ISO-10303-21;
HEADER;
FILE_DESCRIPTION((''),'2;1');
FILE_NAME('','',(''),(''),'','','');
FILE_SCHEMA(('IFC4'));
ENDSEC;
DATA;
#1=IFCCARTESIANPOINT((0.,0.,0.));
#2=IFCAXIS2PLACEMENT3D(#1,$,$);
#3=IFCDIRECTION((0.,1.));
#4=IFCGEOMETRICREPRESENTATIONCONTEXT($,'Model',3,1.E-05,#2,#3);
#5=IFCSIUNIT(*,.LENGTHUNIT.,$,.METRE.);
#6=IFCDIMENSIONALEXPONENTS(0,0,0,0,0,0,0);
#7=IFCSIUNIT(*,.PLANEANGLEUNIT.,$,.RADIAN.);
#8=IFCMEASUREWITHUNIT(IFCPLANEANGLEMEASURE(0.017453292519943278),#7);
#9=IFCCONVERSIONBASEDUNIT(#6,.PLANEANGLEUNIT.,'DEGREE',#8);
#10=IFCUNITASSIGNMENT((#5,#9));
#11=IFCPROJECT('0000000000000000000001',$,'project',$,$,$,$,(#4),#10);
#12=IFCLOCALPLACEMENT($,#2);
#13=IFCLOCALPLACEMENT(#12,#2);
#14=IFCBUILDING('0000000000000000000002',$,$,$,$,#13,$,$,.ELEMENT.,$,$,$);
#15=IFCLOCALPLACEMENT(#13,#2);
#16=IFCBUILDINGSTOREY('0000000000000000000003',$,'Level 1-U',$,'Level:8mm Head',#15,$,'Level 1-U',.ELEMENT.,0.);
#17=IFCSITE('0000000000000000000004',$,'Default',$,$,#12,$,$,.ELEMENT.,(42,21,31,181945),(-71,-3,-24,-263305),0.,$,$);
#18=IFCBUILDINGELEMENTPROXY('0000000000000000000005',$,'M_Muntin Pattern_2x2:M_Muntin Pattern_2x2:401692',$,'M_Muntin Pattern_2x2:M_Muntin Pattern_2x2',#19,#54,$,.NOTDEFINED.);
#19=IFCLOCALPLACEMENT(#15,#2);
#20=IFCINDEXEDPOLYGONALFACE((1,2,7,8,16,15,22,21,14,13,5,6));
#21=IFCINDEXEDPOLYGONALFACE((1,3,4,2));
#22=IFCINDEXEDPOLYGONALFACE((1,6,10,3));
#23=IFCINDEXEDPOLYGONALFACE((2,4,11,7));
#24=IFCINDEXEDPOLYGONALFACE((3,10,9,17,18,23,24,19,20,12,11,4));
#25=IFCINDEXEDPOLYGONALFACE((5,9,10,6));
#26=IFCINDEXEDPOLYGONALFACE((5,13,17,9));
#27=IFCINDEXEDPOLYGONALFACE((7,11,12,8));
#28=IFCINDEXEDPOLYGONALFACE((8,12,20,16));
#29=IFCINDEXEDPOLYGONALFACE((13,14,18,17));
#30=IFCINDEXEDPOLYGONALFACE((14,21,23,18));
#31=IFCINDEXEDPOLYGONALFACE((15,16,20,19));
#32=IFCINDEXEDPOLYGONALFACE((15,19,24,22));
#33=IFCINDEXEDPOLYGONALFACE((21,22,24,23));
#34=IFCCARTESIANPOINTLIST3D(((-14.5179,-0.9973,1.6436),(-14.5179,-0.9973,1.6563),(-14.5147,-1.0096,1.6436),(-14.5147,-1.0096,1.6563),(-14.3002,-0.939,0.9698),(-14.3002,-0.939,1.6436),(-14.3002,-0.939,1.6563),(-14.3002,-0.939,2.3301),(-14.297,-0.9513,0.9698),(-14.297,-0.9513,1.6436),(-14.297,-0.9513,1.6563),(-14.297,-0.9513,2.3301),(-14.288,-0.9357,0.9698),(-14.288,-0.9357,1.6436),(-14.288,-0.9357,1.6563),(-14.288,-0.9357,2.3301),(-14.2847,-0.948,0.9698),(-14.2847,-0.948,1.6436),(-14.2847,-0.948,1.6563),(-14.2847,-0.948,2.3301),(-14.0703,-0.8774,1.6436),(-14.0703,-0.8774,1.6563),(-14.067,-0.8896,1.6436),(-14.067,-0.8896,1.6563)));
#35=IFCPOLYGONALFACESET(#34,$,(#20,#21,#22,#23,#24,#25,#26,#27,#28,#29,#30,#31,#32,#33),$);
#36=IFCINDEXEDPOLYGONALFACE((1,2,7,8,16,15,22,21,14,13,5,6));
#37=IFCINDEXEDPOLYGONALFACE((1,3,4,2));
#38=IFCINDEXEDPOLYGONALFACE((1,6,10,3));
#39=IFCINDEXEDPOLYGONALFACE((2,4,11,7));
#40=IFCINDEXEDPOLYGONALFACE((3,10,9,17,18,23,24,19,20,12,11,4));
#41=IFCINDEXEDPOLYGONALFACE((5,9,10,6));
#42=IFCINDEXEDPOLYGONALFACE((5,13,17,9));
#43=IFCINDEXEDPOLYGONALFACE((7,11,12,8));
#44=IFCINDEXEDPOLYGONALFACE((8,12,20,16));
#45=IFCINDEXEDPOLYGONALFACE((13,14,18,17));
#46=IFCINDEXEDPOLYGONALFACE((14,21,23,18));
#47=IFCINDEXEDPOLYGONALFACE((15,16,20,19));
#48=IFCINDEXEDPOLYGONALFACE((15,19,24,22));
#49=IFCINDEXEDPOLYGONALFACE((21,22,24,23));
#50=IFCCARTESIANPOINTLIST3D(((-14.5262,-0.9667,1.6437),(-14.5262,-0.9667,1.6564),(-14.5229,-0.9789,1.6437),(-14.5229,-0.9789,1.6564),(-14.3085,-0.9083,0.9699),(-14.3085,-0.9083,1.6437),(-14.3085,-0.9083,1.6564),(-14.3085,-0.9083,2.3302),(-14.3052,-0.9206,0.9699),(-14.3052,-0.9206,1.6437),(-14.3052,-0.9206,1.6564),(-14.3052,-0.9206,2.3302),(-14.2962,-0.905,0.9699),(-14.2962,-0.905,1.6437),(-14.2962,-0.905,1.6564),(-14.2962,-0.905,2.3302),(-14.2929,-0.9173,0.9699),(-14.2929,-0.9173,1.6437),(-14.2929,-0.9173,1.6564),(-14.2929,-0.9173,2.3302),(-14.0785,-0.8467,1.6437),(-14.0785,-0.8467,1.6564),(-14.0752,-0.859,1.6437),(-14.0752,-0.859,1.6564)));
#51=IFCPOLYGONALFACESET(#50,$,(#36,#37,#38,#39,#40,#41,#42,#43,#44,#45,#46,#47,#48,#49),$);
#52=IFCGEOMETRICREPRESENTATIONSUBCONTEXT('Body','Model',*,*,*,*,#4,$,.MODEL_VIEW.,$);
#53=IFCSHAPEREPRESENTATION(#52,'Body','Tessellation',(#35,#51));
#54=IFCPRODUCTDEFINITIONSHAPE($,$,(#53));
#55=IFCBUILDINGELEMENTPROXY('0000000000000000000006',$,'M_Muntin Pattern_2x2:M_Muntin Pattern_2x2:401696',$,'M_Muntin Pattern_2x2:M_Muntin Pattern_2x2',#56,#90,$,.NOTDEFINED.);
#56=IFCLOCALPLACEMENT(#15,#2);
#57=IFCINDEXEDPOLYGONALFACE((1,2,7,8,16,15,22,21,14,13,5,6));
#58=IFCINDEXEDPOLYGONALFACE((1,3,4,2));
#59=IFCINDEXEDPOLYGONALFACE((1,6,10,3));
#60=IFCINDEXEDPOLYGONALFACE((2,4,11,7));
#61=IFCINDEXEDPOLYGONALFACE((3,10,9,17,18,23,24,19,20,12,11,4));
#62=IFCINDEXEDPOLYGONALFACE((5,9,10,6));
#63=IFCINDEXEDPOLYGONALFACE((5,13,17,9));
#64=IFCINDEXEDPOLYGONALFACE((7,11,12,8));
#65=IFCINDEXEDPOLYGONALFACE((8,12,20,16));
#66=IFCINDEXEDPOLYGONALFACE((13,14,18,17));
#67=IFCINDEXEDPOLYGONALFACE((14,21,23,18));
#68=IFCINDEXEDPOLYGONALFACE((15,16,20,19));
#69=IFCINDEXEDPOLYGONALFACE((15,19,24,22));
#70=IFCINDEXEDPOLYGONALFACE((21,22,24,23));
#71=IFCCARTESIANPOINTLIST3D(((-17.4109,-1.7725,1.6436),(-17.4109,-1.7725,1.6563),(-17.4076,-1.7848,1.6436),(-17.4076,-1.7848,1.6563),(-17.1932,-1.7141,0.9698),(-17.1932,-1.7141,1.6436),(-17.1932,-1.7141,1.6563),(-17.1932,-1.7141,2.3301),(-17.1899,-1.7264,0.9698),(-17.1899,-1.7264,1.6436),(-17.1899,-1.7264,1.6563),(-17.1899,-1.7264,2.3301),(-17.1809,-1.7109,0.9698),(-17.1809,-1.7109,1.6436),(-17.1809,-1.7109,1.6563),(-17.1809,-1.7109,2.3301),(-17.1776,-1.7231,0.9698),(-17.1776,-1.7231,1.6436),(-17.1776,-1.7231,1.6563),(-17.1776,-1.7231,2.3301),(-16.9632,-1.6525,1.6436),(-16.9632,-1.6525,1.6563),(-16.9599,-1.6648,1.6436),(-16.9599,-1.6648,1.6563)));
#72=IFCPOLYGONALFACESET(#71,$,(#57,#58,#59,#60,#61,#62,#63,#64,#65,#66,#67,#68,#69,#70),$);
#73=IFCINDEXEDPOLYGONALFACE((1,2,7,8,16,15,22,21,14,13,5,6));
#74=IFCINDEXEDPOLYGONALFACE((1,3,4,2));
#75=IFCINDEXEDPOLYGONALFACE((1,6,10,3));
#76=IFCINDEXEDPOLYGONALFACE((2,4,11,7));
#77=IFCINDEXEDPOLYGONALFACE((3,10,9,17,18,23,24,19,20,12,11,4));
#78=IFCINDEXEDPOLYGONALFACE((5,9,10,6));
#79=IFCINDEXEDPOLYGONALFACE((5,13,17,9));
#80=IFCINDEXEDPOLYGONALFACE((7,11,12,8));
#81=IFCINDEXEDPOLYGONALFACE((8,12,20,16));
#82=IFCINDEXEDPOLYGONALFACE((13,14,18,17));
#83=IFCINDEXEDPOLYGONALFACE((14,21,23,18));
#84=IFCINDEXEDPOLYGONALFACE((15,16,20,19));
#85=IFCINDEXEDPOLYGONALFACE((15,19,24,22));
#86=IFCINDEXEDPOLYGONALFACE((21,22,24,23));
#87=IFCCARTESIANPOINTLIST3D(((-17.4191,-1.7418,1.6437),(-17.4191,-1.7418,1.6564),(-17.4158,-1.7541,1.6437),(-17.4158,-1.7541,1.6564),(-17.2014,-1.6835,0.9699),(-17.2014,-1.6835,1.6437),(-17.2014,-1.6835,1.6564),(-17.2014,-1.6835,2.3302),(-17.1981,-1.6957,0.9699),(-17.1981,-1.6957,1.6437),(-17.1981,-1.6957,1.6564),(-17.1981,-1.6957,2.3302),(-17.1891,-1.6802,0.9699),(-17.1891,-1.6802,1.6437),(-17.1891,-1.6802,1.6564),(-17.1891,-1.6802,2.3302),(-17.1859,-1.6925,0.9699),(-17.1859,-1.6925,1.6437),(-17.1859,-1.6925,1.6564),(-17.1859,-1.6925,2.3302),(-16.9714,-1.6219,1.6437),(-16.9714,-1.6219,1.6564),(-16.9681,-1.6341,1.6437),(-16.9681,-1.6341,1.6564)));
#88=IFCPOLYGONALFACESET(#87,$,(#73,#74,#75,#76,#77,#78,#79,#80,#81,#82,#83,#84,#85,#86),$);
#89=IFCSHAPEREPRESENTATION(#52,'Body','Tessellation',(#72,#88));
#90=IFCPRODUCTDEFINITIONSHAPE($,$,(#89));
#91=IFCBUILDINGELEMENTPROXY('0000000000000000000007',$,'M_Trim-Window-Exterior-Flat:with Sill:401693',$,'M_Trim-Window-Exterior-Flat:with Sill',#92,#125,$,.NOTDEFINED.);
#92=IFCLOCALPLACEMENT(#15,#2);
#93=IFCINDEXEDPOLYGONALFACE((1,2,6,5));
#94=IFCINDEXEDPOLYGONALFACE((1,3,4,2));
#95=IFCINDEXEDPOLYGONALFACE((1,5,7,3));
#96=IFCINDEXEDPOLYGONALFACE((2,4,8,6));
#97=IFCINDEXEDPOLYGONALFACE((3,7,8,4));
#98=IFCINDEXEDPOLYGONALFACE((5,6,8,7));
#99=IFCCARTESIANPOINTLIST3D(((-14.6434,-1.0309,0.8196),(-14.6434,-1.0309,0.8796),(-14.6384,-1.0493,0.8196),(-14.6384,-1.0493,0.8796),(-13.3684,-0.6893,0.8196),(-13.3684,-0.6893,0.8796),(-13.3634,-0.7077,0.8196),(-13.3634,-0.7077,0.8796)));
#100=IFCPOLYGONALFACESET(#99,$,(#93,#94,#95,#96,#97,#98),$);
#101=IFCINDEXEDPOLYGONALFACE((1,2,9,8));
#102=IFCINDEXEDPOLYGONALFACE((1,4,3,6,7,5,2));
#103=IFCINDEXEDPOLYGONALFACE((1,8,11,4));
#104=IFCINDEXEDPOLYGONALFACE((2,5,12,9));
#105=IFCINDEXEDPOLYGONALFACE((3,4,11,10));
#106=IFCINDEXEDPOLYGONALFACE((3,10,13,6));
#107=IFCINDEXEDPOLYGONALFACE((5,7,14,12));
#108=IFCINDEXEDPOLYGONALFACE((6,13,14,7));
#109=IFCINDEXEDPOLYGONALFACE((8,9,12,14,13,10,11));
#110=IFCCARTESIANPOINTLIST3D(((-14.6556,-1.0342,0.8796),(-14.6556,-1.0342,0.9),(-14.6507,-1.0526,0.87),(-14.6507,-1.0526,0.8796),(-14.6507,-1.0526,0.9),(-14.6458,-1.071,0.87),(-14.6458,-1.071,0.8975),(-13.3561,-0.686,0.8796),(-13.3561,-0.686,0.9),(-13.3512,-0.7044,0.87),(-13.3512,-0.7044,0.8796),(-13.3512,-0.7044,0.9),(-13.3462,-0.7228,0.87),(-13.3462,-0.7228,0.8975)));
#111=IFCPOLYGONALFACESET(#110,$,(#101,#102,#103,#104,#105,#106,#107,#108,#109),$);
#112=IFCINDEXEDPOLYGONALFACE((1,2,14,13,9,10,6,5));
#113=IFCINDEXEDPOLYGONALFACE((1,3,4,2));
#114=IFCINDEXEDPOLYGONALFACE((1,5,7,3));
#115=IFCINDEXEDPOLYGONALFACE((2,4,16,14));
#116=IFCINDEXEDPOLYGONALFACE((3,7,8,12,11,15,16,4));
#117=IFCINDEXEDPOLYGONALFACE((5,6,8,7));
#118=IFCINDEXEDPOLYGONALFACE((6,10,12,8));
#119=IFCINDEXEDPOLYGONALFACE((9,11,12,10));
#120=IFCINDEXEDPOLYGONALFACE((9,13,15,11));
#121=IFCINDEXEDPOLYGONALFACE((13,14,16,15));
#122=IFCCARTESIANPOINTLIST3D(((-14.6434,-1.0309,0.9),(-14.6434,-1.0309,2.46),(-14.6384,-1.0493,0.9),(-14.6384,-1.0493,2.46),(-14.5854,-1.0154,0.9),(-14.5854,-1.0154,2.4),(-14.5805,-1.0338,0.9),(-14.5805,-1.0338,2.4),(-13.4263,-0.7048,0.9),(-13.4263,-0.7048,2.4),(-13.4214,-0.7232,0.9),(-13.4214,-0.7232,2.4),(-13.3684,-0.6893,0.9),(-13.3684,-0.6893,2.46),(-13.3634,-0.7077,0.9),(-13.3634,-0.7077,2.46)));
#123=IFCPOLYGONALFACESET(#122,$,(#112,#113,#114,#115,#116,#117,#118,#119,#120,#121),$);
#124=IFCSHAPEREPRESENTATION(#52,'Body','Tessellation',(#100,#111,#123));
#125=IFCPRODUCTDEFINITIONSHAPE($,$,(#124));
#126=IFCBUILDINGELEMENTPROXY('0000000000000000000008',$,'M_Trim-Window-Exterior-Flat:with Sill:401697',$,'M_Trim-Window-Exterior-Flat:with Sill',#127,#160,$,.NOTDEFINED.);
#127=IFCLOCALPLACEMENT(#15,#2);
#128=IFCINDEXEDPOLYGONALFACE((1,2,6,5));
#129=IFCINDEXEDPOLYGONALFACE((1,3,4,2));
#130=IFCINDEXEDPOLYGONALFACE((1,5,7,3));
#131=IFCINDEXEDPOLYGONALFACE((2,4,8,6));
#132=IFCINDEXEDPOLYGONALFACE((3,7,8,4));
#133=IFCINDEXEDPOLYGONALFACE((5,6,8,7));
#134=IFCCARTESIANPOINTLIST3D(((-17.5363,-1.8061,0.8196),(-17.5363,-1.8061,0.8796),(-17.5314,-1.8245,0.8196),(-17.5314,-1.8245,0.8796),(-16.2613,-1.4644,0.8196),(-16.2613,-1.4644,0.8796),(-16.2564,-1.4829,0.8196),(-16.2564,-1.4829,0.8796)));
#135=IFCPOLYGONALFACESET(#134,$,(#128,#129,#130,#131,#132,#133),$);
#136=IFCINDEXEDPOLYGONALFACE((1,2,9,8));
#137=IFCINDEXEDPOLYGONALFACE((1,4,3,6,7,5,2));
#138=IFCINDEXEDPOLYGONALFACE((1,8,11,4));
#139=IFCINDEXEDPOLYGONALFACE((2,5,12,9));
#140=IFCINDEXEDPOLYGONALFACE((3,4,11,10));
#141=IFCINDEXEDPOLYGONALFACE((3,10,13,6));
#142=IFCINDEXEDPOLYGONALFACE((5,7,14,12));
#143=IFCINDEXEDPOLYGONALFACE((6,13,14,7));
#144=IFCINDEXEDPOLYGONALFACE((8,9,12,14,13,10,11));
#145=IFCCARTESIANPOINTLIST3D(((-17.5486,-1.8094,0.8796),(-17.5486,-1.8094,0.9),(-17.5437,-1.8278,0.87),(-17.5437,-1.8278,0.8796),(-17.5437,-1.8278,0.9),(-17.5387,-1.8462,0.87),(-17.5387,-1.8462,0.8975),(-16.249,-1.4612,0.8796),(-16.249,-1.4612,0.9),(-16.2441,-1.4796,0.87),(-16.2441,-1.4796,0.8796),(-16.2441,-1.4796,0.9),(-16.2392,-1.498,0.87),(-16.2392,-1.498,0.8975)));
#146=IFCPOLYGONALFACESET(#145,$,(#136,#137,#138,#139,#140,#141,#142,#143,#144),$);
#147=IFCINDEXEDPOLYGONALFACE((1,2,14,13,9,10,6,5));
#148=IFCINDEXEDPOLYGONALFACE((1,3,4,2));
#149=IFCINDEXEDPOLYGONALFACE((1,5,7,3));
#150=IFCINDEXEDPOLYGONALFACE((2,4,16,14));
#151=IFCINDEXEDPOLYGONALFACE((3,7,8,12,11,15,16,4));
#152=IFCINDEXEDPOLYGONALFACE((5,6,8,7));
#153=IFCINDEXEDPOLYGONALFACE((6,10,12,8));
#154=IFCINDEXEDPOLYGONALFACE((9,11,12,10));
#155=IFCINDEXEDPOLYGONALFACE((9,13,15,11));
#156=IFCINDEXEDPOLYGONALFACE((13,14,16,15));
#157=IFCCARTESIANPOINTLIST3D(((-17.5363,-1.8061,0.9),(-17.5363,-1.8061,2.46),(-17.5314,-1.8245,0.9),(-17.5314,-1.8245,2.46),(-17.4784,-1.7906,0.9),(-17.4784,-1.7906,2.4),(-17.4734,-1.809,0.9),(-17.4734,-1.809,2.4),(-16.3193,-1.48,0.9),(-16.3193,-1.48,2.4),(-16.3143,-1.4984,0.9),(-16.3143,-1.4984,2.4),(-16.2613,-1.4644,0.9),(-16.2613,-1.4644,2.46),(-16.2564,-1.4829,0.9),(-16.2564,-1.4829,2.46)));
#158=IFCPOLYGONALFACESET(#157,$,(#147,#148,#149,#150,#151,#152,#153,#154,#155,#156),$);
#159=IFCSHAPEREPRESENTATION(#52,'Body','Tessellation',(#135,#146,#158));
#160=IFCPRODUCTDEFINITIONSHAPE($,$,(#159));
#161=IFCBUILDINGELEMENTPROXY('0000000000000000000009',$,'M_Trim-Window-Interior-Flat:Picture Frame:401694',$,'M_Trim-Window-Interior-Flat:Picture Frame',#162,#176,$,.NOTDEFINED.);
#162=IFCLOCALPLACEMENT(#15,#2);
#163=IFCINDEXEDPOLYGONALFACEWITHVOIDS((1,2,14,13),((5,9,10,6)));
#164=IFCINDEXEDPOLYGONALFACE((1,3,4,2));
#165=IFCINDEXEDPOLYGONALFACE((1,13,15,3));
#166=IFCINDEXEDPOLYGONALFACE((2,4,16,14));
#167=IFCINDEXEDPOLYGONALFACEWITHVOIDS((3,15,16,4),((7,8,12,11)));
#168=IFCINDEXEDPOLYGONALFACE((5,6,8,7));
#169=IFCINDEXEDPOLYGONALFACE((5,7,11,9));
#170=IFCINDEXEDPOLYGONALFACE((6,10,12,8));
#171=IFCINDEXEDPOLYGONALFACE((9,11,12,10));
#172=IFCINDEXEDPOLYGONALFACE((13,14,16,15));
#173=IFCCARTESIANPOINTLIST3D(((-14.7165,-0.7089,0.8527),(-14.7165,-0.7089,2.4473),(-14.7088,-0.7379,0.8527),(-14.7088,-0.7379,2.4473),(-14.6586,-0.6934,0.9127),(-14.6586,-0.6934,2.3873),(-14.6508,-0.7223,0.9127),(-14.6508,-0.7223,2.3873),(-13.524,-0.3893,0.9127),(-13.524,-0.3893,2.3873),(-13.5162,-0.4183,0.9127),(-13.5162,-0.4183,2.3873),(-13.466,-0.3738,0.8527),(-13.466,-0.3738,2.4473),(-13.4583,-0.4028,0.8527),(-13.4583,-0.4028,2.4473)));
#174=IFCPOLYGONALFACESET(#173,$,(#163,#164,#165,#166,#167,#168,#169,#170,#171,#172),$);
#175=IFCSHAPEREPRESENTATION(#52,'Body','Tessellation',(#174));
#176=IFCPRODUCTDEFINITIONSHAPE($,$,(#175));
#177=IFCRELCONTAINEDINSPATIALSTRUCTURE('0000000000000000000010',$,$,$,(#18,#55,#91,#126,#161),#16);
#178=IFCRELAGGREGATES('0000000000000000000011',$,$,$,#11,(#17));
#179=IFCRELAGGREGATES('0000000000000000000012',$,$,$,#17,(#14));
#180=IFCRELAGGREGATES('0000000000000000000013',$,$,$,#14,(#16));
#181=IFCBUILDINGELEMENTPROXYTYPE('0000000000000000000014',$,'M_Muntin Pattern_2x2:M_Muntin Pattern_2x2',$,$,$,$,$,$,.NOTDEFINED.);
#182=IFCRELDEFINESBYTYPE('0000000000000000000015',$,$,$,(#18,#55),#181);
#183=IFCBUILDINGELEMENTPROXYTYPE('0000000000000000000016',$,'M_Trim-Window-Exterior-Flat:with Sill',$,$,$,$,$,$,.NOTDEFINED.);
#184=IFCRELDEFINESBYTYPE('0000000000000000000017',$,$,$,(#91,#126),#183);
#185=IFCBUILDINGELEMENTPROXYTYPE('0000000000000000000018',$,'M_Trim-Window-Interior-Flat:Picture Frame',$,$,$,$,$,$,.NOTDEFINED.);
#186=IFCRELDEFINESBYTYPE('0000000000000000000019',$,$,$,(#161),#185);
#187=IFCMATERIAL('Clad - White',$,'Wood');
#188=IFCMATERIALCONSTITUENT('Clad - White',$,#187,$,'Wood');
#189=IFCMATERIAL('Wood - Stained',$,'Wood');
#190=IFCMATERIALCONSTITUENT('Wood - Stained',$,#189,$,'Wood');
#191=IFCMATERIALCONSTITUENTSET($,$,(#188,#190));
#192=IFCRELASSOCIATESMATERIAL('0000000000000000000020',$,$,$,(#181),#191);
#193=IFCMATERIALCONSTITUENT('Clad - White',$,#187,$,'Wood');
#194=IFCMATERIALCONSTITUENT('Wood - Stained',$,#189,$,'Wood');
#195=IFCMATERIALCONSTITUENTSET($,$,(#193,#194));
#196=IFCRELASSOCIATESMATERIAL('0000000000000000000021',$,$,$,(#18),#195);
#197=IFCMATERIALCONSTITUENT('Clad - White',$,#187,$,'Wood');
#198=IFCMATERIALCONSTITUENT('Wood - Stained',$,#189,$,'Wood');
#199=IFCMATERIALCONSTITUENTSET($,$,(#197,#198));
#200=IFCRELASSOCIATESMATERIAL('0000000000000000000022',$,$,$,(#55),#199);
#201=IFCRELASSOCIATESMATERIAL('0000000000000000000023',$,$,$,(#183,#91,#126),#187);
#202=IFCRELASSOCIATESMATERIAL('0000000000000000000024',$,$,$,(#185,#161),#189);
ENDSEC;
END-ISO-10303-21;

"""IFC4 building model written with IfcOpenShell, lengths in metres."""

from ifc_helpers import new_model, entity, si_unit, converted_unit, direction, frame, origin, place, context, subcontext, project, spatial, indexed_curve, outline, extrude, source, transform, mapped, material, constituent, constituent_set, type_object, type_shapes, element, save


model = new_model("IFC4")

# Units and contexts
model_context = context("Model", 3, precision=1e-05, world=origin(), true_north=direction((0.0, 1.0)))
body_context = subcontext(model_context, "Body", "Model", "MODEL_VIEW")
ifc_project = project(units=[si_unit("LENGTHUNIT", "METRE"), converted_unit("PLANEANGLEUNIT", "DEGREE", entity("IfcPlaneAngleMeasure", 0.017453292519943278), si_unit("PLANEANGLEUNIT", "RADIAN"), dimensions=[0, 0, 0, 0, 0, 0, 0])], contexts=[model_context])

# Site, building, storey
site_placement = place(None, origin())
site = spatial("IfcSite", under=ifc_project, at=site_placement, Name="Default", CompositionType="ELEMENT", RefLatitude=(42, 21, 31, 181945), RefLongitude=(-71, -3, -24, -263305), RefElevation=0.0)
building_placement = place(site_placement, origin())
building = spatial("IfcBuilding", under=site, at=building_placement, CompositionType="ELEMENT")
storey_placement = place(building_placement, origin())
storey = spatial("IfcBuildingStorey", under=building, at=storey_placement, Name="Level 1-U", ObjectType="Level:8mm Head", LongName="Level 1-U", CompositionType="ELEMENT", Elevation=0.0)

# Building element proxies
ifc_material_1 = material(Name="Clad - White", Category="Wood")
ifc_material_2 = material(Name="Wood - Stained", Category="Wood")
ifc_constituent_1 = constituent(ifc_material_1, Name="Clad - White", Category="Wood")
ifc_constituent_2 = constituent(ifc_material_2, Name="Wood - Stained", Category="Wood")
ifc_constituent_set_1 = constituent_set(constituents=[ifc_constituent_1, ifc_constituent_2])
ifc_constituent_3 = constituent(ifc_material_1, Name="Clad - White", Category="Wood")
ifc_constituent_4 = constituent(ifc_material_2, Name="Wood - Stained", Category="Wood")
ifc_constituent_set_2 = constituent_set(constituents=[ifc_constituent_3, ifc_constituent_4])
building_element_proxy_type_1 = type_object("IfcBuildingElementProxyType", Name="M_Muntin Pattern_2x2:M_Muntin Pattern_2x2", PredefinedType="NOTDEFINED", material=ifc_constituent_set_2)
shared_shape_1 = source(origin(), body_context, "Body", "SweptSolid", [
    extrude(outline(indexed_curve([(0.0064, -0.0064), (0.6801, -0.0064), (0.6801, 0.0063), (0.0064, 0.0063), (0.0064, 0.2317), (-0.0063, 0.2317), (-0.0063, 0.0063), (-0.6802, 0.0063), (-0.6802, -0.0064), (-0.0063, -0.0064), (-0.0063, -0.2317), (0.0064, -0.2317), (0.0064, -0.0064)], self_intersect=False)), frame((0.0, -0.0222, 0.6801), z_axis=(0.0, 1.0, 0.0), x_axis=(0.0, 0.0, 1.0)), (0.0, 0.0, 1.0), 0.0127),
    extrude(outline(indexed_curve([(0.0064, -0.0064), (0.6802, -0.0064), (0.6802, 0.0063), (0.0064, 0.0063), (0.0064, 0.2317), (-0.0063, 0.2317), (-0.0063, 0.0063), (-0.6802, 0.0063), (-0.6802, -0.0064), (-0.0063, -0.0064), (-0.0063, -0.2317), (0.0064, -0.2317), (0.0064, -0.0064)], self_intersect=False)), frame((0.0, 0.0095, 0.6802), z_axis=(0.0, 1.0, 0.0), x_axis=(0.0, 0.0, 1.0)), (0.0, 0.0, 1.0), 0.0127),
])
type_shapes(building_element_proxy_type_1, [shared_shape_1])
proxy_1_placement = place(storey_placement, frame((-14.2966, -0.9281, 0.9699), z_axis=(0.0, 0.0, 1.0), x_axis=(0.965926, 0.258819, 0.0)))
element("IfcBuildingElementProxy", 1, at=proxy_1_placement, inside=storey, type_object=building_element_proxy_type_1, material=ifc_constituent_set_1, Name="M_Muntin Pattern_2x2:M_Muntin Pattern_2x2:401692", ObjectType="M_Muntin Pattern_2x2:M_Muntin Pattern_2x2", PredefinedType="NOTDEFINED", context=body_context, shape_type="MappedRepresentation", body=[
    mapped(shared_shape_1, transform((0.0, 0.0, 0.0), scale=1.0)),
])
ifc_constituent_5 = constituent(ifc_material_1, Name="Clad - White", Category="Wood")
ifc_constituent_6 = constituent(ifc_material_2, Name="Wood - Stained", Category="Wood")
ifc_constituent_set_3 = constituent_set(constituents=[ifc_constituent_5, ifc_constituent_6])
proxy_2_placement = place(storey_placement, frame((-17.1895, -1.7033, 0.9699), z_axis=(0.0, 0.0, 1.0), x_axis=(0.965926, 0.258819, 0.0)))
element("IfcBuildingElementProxy", 2, at=proxy_2_placement, inside=storey, type_object=building_element_proxy_type_1, material=ifc_constituent_set_3, Name="M_Muntin Pattern_2x2:M_Muntin Pattern_2x2:401696", ObjectType="M_Muntin Pattern_2x2:M_Muntin Pattern_2x2", PredefinedType="NOTDEFINED", context=body_context, shape_type="MappedRepresentation", body=[
    mapped(shared_shape_1, transform((0.0, 0.0, 0.0), scale=1.0)),
])
building_element_proxy_type_2 = type_object("IfcBuildingElementProxyType", Name="M_Trim-Window-Exterior-Flat:with Sill", PredefinedType="NOTDEFINED", material=ifc_material_1)
shared_shape_2 = source(origin(), body_context, "Body", "SweptSolid", [
    extrude(outline(indexed_curve([(-0.66, -0.03), (0.66, -0.03), (0.66, 0.03), (-0.66, 0.03), (-0.66, -0.03)], self_intersect=False)), frame((0.0, -1.5504, 0.0), z_axis=(0.0, 0.0, 1.0), x_axis=(-1.0, 0.0, 0.0)), (0.0, 0.0, 1.0), 0.019),
    extrude(outline(indexed_curve([(-0.019, -0.0152), (0.0, -0.0152), (0.0, -0.0057), (0.019, -0.0057), (0.019, 0.0148), (0.0, 0.0148), (-0.019, 0.0123), (-0.019, -0.0152)], self_intersect=False)), frame((-0.6727, -1.5148, 0.019), z_axis=(1.0, 0.0, 0.0), x_axis=(0.0, 0.0, -1.0)), (0.0, 0.0, 1.0), 1.3454),
    extrude(outline(indexed_curve([(-0.795, -0.66), (0.765, -0.66), (0.765, -0.6), (-0.735, -0.6), (-0.735, 0.6), (0.765, 0.6), (0.765, 0.66), (-0.795, 0.66), (-0.795, -0.66)], self_intersect=False)), frame((0.0, -0.735, 0.0), z_axis=(0.0, 0.0, 1.0), x_axis=(0.0, -1.0, 0.0)), (0.0, 0.0, 1.0), 0.019),
])
type_shapes(building_element_proxy_type_2, [shared_shape_2])
for number, where, z_axis, x_axis, name in (
    (3, (-14.0059, -0.8601, 2.4), (0.258819, -0.965926, 0.0), (0.965926, 0.258819, 0.0), "M_Trim-Window-Exterior-Flat:with Sill:401693"),
    (4, (-16.8988, -1.6353, 2.4), (0.258819, -0.965926, 0.0), (0.965926, 0.258819, 0.0), "M_Trim-Window-Exterior-Flat:with Sill:401697"),
):
    element("IfcBuildingElementProxy", number, at=place(storey_placement, frame(where, z_axis=z_axis, x_axis=x_axis)), inside=storey, type_object=building_element_proxy_type_2, material=ifc_material_1, Name=name, ObjectType="M_Trim-Window-Exterior-Flat:with Sill", PredefinedType="NOTDEFINED", context=body_context, shape_type="MappedRepresentation", body=[
        mapped(shared_shape_2, transform((0.0, 0.0, 0.0), scale=1.0)),
    ])
building_element_proxy_type_3 = type_object("IfcBuildingElementProxyType", Name="M_Trim-Window-Interior-Flat:Picture Frame", PredefinedType="NOTDEFINED", material=ifc_material_2)
shared_shape_3 = source(origin(), body_context, "Body", "SweptSolid", [
    extrude(outline(indexed_curve([(-0.6473, -0.7973), (0.6473, -0.7973), (0.6473, 0.7973), (-0.6473, 0.7973), (-0.6473, -0.7973)], self_intersect=False), holes=[indexed_curve([(-0.5873, -0.7373), (-0.5873, 0.7373), (0.5873, 0.7373), (0.5873, -0.7373), (-0.5873, -0.7373)], self_intersect=False)]), frame((0.0, -0.75, 0.0), z_axis=(0.0, 0.0, 1.0), x_axis=(-1.0, 0.0, 0.0)), (0.0, 0.0, 1.0), 0.03),
])
type_shapes(building_element_proxy_type_3, [shared_shape_3])
for number, where, z_axis, x_axis, name in (
    (5, (-14.0835, -0.5703, 2.4), (-0.258819, 0.965926, 0.0), (-0.965926, -0.258819, 0.0), "M_Trim-Window-Interior-Flat:Picture Frame:401694"),
):
    element("IfcBuildingElementProxy", number, at=place(storey_placement, frame(where, z_axis=z_axis, x_axis=x_axis)), inside=storey, type_object=building_element_proxy_type_3, material=ifc_material_2, Name=name, ObjectType="M_Trim-Window-Interior-Flat:Picture Frame", PredefinedType="NOTDEFINED", context=body_context, shape_type="MappedRepresentation", body=[
        mapped(shared_shape_3, transform((0.0, 0.0, 0.0), scale=1.0)),
    ])

save(model, "model.ifc")
